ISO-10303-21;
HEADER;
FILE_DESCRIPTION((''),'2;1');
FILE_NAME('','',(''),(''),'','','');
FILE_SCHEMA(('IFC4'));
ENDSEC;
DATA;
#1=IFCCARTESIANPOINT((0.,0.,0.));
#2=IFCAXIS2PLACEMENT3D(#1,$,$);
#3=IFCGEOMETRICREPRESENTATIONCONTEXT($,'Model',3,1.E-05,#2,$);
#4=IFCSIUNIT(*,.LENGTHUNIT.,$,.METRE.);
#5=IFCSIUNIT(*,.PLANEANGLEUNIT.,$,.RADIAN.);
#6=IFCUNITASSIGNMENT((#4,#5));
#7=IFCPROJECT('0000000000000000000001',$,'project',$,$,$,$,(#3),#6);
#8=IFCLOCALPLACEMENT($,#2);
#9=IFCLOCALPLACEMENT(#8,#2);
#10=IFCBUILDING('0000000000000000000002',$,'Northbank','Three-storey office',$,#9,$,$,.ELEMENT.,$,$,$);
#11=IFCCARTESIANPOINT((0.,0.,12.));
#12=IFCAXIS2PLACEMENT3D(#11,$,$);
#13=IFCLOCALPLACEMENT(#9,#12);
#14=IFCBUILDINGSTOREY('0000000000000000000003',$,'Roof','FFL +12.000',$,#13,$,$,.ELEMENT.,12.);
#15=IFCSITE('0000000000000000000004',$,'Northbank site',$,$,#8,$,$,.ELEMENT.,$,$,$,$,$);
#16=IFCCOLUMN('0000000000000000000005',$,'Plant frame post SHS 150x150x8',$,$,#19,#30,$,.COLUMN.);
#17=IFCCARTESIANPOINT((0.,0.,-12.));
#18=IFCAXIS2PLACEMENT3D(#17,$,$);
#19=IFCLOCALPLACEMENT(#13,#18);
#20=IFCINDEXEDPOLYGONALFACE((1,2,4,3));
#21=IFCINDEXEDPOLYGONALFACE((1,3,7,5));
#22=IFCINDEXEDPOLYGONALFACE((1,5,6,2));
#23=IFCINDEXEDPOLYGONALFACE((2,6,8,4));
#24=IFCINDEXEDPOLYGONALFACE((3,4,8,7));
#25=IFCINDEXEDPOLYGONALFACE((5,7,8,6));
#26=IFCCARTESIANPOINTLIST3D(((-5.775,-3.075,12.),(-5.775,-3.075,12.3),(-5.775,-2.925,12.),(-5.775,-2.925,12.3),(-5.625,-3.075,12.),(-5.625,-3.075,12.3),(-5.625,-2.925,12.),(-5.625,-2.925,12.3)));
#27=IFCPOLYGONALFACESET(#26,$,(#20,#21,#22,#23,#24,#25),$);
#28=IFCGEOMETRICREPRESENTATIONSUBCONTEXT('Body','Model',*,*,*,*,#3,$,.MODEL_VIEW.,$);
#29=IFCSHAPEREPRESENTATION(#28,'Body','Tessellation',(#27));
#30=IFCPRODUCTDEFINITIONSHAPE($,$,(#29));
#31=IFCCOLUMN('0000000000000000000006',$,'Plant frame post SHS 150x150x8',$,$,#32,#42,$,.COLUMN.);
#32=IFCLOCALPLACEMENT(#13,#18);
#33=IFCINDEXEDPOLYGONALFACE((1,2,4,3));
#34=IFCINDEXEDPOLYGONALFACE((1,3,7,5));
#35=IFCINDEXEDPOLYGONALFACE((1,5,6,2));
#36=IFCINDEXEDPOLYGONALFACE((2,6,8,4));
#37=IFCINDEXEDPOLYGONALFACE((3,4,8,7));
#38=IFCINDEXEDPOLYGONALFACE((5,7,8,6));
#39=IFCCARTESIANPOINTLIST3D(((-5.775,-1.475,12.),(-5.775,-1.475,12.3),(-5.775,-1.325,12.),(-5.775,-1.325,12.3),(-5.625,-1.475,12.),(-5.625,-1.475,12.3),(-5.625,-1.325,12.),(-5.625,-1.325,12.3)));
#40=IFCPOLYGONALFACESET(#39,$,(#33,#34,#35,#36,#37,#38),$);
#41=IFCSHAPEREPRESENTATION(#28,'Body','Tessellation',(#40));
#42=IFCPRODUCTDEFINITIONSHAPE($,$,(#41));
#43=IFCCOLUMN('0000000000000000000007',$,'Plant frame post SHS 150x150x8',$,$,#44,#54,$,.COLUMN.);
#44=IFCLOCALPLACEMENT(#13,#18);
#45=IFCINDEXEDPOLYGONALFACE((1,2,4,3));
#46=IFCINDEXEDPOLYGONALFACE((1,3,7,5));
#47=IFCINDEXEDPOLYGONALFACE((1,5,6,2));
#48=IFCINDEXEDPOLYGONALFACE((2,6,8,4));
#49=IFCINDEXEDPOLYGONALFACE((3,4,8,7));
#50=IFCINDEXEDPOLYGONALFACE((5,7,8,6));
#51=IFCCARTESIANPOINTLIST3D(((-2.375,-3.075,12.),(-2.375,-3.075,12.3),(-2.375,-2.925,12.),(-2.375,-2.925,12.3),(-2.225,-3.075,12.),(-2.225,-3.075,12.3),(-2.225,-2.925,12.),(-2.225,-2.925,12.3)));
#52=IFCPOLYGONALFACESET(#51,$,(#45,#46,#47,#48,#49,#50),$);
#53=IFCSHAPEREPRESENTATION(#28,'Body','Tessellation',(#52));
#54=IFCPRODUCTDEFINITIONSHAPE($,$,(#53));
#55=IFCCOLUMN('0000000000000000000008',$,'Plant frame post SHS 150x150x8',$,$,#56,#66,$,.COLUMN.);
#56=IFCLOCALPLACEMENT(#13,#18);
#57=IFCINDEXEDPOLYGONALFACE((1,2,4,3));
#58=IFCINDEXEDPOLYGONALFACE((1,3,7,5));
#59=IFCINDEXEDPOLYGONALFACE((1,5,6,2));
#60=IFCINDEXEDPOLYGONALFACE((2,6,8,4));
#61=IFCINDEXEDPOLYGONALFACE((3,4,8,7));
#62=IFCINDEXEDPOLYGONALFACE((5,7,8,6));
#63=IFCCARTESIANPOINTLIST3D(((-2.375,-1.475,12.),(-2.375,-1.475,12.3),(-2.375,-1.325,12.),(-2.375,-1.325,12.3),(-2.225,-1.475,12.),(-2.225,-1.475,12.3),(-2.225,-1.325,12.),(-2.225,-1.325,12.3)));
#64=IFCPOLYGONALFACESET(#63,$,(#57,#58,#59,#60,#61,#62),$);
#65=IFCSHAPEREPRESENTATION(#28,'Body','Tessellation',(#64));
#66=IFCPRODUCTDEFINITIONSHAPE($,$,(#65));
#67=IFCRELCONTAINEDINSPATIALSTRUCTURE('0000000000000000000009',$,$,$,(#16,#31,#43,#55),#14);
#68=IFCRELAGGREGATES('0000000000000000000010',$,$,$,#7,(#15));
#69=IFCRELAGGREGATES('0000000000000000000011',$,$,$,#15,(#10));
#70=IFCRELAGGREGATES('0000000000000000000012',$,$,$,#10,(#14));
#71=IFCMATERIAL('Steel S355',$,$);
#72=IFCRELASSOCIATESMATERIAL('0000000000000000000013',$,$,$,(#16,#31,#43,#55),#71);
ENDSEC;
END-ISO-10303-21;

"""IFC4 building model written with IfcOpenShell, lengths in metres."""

from ifc_helpers import new_model, si_unit, frame, origin, place, context, subcontext, project, spatial, rectangle, extrude, material, element, save


model = new_model("IFC4")

# Units and contexts
model_context = context("Model", 3, precision=1e-05, world=origin())
body_context = subcontext(model_context, "Body", "Model", "MODEL_VIEW")
ifc_project = project(units=[si_unit("LENGTHUNIT", "METRE"), si_unit("PLANEANGLEUNIT", "RADIAN")], contexts=[model_context])

# Site, building, storey
site_placement = place(None, origin())
site = spatial("IfcSite", under=ifc_project, at=site_placement, Name="Northbank site", CompositionType="ELEMENT")
building_placement = place(site_placement, origin())
building = spatial("IfcBuilding", under=site, at=building_placement, Name="Northbank", Description="Three-storey office", CompositionType="ELEMENT")
storey_placement = place(building_placement, frame((0.0, 0.0, 12.0)))
storey = spatial("IfcBuildingStorey", under=building, at=storey_placement, Name="Roof", Description="FFL +12.000", CompositionType="ELEMENT", Elevation=12.0)

# Columns
ifc_material_1 = material(Name="Steel S355")
column_1_placement = place(storey_placement, frame((0.0, 0.0, -12.0)))
element("IfcColumn", 1, at=column_1_placement, inside=storey, material=ifc_material_1, Name="Plant frame post SHS 150x150x8", PredefinedType="COLUMN", context=body_context, shape_type="SweptSolid", body=[
    extrude(rectangle(XDim=0.15, YDim=0.15), frame((-5.7, -3.0, 12.0)), (0.0, 0.0, 1.0), 0.3),
])
column_2_placement = place(storey_placement, frame((0.0, 0.0, -12.0)))
element("IfcColumn", 2, at=column_2_placement, inside=storey, material=ifc_material_1, Name="Plant frame post SHS 150x150x8", PredefinedType="COLUMN", context=body_context, shape_type="SweptSolid", body=[
    extrude(rectangle(XDim=0.15, YDim=0.15), frame((-5.7, -1.4, 12.0)), (0.0, 0.0, 1.0), 0.3),
])
column_3_placement = place(storey_placement, frame((0.0, 0.0, -12.0)))
element("IfcColumn", 3, at=column_3_placement, inside=storey, material=ifc_material_1, Name="Plant frame post SHS 150x150x8", PredefinedType="COLUMN", context=body_context, shape_type="SweptSolid", body=[
    extrude(rectangle(XDim=0.15, YDim=0.15), frame((-2.3, -3.0, 12.0)), (0.0, 0.0, 1.0), 0.3),
])
column_4_placement = place(storey_placement, frame((0.0, 0.0, -12.0)))
element("IfcColumn", 4, at=column_4_placement, inside=storey, material=ifc_material_1, Name="Plant frame post SHS 150x150x8", PredefinedType="COLUMN", context=body_context, shape_type="SweptSolid", body=[
    extrude(rectangle(XDim=0.15, YDim=0.15), frame((-2.3, -1.4, 12.0)), (0.0, 0.0, 1.0), 0.3),
])

save(model, "model.ifc")
